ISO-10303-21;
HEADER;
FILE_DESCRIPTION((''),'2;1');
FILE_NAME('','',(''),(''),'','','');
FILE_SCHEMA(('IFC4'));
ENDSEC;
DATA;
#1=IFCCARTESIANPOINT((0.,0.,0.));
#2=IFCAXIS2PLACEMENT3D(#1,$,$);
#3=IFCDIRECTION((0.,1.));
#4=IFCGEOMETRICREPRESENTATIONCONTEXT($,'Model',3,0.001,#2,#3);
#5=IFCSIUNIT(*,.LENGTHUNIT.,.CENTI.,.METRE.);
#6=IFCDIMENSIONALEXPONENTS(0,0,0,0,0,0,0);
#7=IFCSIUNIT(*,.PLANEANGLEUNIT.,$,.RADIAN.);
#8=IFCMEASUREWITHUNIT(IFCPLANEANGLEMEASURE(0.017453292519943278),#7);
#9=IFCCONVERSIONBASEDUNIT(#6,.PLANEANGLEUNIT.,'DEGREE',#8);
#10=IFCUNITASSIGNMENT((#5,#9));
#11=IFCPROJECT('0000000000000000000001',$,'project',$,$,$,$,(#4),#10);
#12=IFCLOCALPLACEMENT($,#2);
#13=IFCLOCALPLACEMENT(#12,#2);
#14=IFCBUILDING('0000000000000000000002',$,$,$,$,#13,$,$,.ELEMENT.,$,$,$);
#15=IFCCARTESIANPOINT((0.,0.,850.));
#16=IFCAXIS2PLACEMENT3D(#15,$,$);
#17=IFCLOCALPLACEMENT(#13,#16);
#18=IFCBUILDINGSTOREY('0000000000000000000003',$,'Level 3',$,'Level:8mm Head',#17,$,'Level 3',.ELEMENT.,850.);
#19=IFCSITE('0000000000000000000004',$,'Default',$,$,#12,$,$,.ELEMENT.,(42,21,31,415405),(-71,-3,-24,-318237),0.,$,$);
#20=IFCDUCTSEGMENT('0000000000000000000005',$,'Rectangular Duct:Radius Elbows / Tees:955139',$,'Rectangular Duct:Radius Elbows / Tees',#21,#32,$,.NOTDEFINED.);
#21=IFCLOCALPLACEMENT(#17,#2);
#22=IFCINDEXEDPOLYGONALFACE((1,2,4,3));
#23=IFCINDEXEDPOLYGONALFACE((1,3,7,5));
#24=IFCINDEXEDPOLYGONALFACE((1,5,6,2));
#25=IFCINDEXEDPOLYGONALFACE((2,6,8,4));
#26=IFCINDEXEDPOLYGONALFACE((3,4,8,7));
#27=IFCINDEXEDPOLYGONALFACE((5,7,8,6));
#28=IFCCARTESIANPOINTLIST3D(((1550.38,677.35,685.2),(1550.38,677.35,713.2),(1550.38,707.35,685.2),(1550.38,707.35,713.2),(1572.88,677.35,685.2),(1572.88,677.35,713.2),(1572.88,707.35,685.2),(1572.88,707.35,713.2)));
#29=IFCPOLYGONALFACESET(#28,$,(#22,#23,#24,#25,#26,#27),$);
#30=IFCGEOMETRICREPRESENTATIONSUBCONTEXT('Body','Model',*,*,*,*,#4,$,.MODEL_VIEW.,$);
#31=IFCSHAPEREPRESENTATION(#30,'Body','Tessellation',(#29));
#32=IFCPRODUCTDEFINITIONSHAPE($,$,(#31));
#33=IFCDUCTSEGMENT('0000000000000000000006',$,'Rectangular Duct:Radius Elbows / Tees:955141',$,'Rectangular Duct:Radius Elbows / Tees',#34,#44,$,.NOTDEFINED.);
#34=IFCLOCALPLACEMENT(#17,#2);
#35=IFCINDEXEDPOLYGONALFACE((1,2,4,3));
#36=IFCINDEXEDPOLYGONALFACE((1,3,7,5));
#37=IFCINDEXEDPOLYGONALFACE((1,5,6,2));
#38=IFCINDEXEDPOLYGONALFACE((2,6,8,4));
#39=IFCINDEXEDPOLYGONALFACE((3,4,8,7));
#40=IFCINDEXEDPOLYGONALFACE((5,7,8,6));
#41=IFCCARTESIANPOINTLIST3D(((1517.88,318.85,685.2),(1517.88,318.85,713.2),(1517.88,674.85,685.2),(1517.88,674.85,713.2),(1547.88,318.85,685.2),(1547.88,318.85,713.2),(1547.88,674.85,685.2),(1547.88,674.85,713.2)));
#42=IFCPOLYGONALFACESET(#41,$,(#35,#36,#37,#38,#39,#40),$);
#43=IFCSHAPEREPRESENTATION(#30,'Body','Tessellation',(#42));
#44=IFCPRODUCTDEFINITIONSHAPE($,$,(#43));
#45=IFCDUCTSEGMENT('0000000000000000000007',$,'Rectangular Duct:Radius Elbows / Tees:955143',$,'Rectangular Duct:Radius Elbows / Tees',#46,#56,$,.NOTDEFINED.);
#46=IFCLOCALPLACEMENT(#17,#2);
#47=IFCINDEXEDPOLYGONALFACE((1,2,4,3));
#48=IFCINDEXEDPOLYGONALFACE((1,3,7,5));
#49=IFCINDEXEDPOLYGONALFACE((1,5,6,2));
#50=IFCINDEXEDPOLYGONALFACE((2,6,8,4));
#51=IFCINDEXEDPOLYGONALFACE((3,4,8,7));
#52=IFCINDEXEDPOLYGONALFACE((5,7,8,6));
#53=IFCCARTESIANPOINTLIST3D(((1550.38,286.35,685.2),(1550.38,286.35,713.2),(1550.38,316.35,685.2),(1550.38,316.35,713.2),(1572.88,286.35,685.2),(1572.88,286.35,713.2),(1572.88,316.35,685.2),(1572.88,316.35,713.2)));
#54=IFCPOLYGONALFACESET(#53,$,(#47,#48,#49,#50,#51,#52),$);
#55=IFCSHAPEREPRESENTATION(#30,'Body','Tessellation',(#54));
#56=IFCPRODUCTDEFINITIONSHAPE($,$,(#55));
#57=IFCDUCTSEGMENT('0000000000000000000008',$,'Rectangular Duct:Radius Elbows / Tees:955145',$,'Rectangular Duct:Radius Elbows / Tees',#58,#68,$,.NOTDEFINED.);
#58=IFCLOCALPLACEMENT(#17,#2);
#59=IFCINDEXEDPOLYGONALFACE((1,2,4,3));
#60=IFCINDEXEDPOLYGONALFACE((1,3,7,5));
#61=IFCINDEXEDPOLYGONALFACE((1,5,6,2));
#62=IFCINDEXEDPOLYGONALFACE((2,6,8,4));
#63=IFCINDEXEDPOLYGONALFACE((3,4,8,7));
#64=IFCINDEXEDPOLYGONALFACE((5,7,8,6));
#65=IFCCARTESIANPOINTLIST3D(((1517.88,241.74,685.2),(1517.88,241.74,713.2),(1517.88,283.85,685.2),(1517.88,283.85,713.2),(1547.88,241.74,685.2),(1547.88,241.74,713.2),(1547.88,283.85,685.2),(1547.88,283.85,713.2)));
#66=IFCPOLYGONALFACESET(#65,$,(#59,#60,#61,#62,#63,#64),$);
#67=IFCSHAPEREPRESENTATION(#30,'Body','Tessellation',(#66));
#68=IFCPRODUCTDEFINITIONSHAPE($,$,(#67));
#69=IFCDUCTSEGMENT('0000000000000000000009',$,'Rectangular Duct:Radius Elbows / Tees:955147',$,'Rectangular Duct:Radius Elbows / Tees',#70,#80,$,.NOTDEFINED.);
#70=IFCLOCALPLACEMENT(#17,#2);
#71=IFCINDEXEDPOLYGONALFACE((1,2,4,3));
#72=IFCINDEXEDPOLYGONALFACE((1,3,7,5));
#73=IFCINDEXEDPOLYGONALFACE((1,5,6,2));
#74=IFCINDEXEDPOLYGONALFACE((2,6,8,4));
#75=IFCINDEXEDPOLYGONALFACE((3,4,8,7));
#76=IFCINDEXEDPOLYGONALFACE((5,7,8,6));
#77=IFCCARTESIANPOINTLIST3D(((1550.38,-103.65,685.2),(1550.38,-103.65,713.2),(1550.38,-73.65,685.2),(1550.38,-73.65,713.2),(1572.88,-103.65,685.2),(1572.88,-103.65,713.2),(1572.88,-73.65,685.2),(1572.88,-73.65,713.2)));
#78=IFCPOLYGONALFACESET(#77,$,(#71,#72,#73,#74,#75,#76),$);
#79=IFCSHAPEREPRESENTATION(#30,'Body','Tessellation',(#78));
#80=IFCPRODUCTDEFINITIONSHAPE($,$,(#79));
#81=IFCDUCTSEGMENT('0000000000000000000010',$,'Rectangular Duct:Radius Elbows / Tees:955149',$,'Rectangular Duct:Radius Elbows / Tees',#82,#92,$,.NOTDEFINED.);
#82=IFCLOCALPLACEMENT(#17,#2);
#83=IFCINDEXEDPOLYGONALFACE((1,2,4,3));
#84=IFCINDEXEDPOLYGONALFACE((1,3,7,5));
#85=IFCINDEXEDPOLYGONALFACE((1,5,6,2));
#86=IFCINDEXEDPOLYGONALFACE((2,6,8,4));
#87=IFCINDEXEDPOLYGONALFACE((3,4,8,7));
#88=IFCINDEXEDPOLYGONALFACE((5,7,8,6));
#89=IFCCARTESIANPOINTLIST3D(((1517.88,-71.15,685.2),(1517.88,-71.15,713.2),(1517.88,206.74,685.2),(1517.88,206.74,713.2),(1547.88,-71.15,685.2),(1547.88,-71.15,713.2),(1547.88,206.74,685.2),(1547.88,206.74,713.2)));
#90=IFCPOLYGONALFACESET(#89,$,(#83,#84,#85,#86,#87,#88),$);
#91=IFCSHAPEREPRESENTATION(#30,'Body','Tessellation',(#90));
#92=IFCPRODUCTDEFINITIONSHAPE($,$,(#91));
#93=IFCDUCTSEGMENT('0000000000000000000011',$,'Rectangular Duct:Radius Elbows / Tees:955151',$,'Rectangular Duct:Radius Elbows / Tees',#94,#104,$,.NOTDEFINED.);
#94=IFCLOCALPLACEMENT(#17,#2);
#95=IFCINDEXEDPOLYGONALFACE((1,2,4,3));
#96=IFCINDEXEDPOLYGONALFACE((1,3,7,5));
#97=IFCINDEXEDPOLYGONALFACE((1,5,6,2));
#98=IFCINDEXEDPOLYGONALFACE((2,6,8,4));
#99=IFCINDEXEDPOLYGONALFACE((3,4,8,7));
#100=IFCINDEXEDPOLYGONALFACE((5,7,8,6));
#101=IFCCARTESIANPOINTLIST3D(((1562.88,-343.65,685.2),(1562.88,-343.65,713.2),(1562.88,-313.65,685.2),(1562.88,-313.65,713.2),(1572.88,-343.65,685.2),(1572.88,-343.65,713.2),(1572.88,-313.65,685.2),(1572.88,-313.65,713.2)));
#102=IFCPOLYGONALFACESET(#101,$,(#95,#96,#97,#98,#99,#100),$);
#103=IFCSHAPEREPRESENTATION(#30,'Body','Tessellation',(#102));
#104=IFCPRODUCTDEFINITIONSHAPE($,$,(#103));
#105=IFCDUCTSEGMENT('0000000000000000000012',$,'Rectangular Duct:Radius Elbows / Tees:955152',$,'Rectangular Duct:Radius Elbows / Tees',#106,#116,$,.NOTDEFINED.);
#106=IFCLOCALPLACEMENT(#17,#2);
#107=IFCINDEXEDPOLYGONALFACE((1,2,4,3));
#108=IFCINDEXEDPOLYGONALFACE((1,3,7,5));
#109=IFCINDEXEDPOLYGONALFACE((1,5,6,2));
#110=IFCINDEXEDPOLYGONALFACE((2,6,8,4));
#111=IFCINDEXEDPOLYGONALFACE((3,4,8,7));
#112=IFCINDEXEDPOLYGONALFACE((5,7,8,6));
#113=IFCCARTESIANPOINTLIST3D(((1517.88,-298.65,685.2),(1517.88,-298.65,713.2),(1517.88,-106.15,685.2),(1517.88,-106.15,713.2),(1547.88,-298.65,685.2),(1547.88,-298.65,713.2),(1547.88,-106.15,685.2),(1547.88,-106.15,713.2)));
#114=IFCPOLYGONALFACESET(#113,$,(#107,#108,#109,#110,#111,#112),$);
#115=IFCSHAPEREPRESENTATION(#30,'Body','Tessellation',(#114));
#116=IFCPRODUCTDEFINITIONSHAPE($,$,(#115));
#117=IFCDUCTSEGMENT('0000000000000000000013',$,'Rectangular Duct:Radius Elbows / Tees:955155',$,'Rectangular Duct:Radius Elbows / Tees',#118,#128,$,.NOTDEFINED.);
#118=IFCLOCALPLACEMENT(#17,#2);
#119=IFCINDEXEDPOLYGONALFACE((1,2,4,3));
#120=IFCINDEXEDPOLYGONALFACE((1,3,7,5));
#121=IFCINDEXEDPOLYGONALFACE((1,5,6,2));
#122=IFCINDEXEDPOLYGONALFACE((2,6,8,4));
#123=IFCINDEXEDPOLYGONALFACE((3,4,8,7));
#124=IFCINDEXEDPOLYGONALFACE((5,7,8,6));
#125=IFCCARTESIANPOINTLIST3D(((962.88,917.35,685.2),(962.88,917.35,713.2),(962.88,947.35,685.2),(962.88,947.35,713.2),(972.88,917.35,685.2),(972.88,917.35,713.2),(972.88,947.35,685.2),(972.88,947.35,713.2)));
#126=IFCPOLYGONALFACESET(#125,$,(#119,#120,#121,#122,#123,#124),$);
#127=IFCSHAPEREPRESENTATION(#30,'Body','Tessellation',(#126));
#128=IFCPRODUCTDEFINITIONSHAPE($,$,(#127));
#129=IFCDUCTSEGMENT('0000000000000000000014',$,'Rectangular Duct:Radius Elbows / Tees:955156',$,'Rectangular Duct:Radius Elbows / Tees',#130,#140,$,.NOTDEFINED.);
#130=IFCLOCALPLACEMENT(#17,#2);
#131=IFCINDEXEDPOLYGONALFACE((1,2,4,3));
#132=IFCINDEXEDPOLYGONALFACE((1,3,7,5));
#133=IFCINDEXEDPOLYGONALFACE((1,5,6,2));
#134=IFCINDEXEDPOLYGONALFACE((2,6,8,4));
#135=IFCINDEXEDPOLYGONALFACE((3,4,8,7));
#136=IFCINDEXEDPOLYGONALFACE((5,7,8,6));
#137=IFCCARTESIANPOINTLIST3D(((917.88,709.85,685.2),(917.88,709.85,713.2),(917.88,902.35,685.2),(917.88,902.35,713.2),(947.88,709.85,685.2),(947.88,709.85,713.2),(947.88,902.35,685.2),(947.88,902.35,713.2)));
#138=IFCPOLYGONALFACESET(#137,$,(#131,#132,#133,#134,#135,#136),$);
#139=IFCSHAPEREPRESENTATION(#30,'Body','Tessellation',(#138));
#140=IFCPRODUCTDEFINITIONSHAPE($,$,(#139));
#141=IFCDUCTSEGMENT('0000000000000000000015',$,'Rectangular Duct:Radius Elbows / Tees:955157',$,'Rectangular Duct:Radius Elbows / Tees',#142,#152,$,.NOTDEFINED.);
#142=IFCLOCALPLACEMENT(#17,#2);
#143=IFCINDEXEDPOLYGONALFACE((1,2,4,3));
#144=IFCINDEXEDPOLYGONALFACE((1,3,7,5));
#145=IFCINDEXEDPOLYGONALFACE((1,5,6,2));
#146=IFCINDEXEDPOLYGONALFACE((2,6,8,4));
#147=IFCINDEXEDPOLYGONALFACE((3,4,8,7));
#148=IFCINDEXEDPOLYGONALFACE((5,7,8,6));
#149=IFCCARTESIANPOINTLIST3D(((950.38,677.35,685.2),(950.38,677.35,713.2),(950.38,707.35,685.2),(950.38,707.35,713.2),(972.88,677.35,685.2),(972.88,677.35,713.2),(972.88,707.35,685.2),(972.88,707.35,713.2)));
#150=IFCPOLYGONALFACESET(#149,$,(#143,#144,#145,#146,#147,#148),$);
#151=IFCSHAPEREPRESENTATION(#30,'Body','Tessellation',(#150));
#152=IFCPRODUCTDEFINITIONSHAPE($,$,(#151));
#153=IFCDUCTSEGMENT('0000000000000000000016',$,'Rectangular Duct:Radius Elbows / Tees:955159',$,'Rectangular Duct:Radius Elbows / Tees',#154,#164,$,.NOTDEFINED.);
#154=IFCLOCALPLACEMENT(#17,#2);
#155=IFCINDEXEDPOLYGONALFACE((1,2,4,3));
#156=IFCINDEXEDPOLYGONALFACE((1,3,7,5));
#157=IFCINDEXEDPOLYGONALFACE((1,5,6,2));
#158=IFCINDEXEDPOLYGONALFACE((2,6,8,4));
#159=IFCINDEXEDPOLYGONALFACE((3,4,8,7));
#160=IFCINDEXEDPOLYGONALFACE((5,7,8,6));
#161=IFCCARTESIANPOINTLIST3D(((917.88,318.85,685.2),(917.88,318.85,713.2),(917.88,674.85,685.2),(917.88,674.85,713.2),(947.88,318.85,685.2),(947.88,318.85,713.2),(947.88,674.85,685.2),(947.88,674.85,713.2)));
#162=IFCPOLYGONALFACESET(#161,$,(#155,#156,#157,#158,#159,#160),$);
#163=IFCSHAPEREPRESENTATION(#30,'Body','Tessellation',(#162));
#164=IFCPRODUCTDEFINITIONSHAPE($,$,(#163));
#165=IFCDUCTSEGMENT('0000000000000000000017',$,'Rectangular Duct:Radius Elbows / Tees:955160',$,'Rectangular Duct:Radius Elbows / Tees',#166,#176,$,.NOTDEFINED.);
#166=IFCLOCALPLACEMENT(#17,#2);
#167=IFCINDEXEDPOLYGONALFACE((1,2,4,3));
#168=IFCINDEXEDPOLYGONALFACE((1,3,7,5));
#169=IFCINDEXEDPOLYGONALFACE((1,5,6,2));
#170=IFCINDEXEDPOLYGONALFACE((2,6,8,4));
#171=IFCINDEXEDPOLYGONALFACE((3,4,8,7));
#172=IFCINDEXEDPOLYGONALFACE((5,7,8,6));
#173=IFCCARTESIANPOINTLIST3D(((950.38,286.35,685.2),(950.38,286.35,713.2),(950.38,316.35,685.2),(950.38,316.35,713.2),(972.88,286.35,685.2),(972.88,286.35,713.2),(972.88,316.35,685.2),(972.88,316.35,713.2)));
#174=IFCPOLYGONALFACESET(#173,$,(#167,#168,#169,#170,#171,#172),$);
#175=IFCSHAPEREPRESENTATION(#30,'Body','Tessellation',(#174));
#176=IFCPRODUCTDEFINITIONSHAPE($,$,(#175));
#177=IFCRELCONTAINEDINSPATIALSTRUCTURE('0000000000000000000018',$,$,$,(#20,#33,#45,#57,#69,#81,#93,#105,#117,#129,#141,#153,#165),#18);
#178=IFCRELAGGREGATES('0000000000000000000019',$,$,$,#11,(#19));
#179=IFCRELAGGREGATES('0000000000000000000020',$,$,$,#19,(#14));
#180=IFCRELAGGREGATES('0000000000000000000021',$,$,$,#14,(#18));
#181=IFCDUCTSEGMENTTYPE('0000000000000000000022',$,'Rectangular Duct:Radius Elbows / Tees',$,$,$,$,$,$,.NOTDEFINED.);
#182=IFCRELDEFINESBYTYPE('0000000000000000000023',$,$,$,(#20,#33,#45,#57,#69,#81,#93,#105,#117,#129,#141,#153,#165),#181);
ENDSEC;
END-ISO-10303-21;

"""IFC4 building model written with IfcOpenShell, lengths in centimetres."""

from ifc_helpers import new_model, entity, si_unit, converted_unit, direction, frame, origin, place, context, subcontext, project, spatial, indexed_curve, outline, extrude, type_object, element, save


model = new_model("IFC4")

# Units and contexts
model_context = context("Model", 3, precision=0.001, world=origin(), true_north=direction((0.0, 1.0)))
body_context = subcontext(model_context, "Body", "Model", "MODEL_VIEW")
ifc_project = project(units=[si_unit("LENGTHUNIT", "METRE", prefix="CENTI"), converted_unit("PLANEANGLEUNIT", "DEGREE", entity("IfcPlaneAngleMeasure", 0.017453292519943278), si_unit("PLANEANGLEUNIT", "RADIAN"), dimensions=[0, 0, 0, 0, 0, 0, 0])], contexts=[model_context])

# Site, building, storey
site_placement = place(None, origin())
site = spatial("IfcSite", under=ifc_project, at=site_placement, Name="Default", CompositionType="ELEMENT", RefLatitude=(42, 21, 31, 415405), RefLongitude=(-71, -3, -24, -318237), RefElevation=0.0)
building_placement = place(site_placement, origin())
building = spatial("IfcBuilding", under=site, at=building_placement, CompositionType="ELEMENT")
storey_placement = place(building_placement, frame((0.0, 0.0, 850.0)))
storey = spatial("IfcBuildingStorey", under=building, at=storey_placement, Name="Level 3", ObjectType="Level:8mm Head", LongName="Level 3", CompositionType="ELEMENT", Elevation=850.0)

# Duct segments
duct_segment_type_1 = type_object("IfcDuctSegmentType", Name="Rectangular Duct:Radius Elbows / Tees", PredefinedType="NOTDEFINED")
duct_segment_1_placement = place(storey_placement, origin())
element("IfcDuctSegment", 1, at=duct_segment_1_placement, inside=storey, type_object=duct_segment_type_1, Name="Rectangular Duct:Radius Elbows / Tees:955139", ObjectType="Rectangular Duct:Radius Elbows / Tees", PredefinedType="NOTDEFINED", context=body_context, shape_type="SweptSolid", body=[
    extrude(outline(indexed_curve([(-11.25, -15.0), (11.25, -15.0), (11.25, 15.0), (-11.25, 15.0), (-11.25, -15.0)], self_intersect=False)), frame((1561.63, 692.35, 685.2)), (0.0, 0.0, 1.0), 28.0),
])
duct_segment_2_placement = place(storey_placement, origin())
element("IfcDuctSegment", 2, at=duct_segment_2_placement, inside=storey, type_object=duct_segment_type_1, Name="Rectangular Duct:Radius Elbows / Tees:955141", ObjectType="Rectangular Duct:Radius Elbows / Tees", PredefinedType="NOTDEFINED", context=body_context, shape_type="SweptSolid", body=[
    extrude(outline(indexed_curve([(-178.0, -15.0), (178.0, -15.0), (178.0, 15.0), (-178.0, 15.0), (-178.0, -15.0)], self_intersect=False)), frame((1532.88, 496.85, 685.2), z_axis=(0.0, 0.0, 1.0), x_axis=(0.0, 1.0, 0.0)), (0.0, 0.0, 1.0), 28.0),
])
duct_segment_3_placement = place(storey_placement, origin())
element("IfcDuctSegment", 3, at=duct_segment_3_placement, inside=storey, type_object=duct_segment_type_1, Name="Rectangular Duct:Radius Elbows / Tees:955143", ObjectType="Rectangular Duct:Radius Elbows / Tees", PredefinedType="NOTDEFINED", context=body_context, shape_type="SweptSolid", body=[
    extrude(outline(indexed_curve([(-11.25, -15.0), (11.25, -15.0), (11.25, 15.0), (-11.25, 15.0), (-11.25, -15.0)], self_intersect=False)), frame((1561.63, 301.35, 685.2)), (0.0, 0.0, 1.0), 28.0),
])
duct_segment_4_placement = place(storey_placement, origin())
element("IfcDuctSegment", 4, at=duct_segment_4_placement, inside=storey, type_object=duct_segment_type_1, Name="Rectangular Duct:Radius Elbows / Tees:955145", ObjectType="Rectangular Duct:Radius Elbows / Tees", PredefinedType="NOTDEFINED", context=body_context, shape_type="SweptSolid", body=[
    extrude(outline(indexed_curve([(-21.05, -15.0), (21.05, -15.0), (21.05, 15.0), (-21.05, 15.0), (-21.05, -15.0)], self_intersect=False)), frame((1532.88, 262.79, 685.2), z_axis=(0.0, 0.0, 1.0), x_axis=(0.0, 1.0, 0.0)), (0.0, 0.0, 1.0), 28.0),
])
duct_segment_5_placement = place(storey_placement, origin())
element("IfcDuctSegment", 5, at=duct_segment_5_placement, inside=storey, type_object=duct_segment_type_1, Name="Rectangular Duct:Radius Elbows / Tees:955147", ObjectType="Rectangular Duct:Radius Elbows / Tees", PredefinedType="NOTDEFINED", context=body_context, shape_type="SweptSolid", body=[
    extrude(outline(indexed_curve([(-11.25, -15.0), (11.25, -15.0), (11.25, 15.0), (-11.25, 15.0), (-11.25, -15.0)], self_intersect=False)), frame((1561.63, -88.65, 685.2)), (0.0, 0.0, 1.0), 28.0),
])
duct_segment_6_placement = place(storey_placement, origin())
element("IfcDuctSegment", 6, at=duct_segment_6_placement, inside=storey, type_object=duct_segment_type_1, Name="Rectangular Duct:Radius Elbows / Tees:955149", ObjectType="Rectangular Duct:Radius Elbows / Tees", PredefinedType="NOTDEFINED", context=body_context, shape_type="SweptSolid", body=[
    extrude(outline(indexed_curve([(-138.95, -15.0), (138.95, -15.0), (138.95, 15.0), (-138.95, 15.0), (-138.95, -15.0)], self_intersect=False)), frame((1532.88, 67.79, 685.2), z_axis=(0.0, 0.0, 1.0), x_axis=(0.0, -1.0, 0.0)), (0.0, 0.0, 1.0), 28.0),
])
duct_segment_7_placement = place(storey_placement, origin())
element("IfcDuctSegment", 7, at=duct_segment_7_placement, inside=storey, type_object=duct_segment_type_1, Name="Rectangular Duct:Radius Elbows / Tees:955151", ObjectType="Rectangular Duct:Radius Elbows / Tees", PredefinedType="NOTDEFINED", context=body_context, shape_type="SweptSolid", body=[
    extrude(outline(indexed_curve([(-5.0, -15.0), (5.0, -15.0), (5.0, 15.0), (-5.0, 15.0), (-5.0, -15.0)], self_intersect=False)), frame((1567.88, -328.65, 685.2)), (0.0, 0.0, 1.0), 28.0),
])
duct_segment_8_placement = place(storey_placement, origin())
element("IfcDuctSegment", 8, at=duct_segment_8_placement, inside=storey, type_object=duct_segment_type_1, Name="Rectangular Duct:Radius Elbows / Tees:955152", ObjectType="Rectangular Duct:Radius Elbows / Tees", PredefinedType="NOTDEFINED", context=body_context, shape_type="SweptSolid", body=[
    extrude(outline(indexed_curve([(-96.25, -15.0), (96.25, -15.0), (96.25, 15.0), (-96.25, 15.0), (-96.25, -15.0)], self_intersect=False)), frame((1532.88, -202.4, 685.2), z_axis=(0.0, 0.0, 1.0), x_axis=(0.0, -1.0, 0.0)), (0.0, 0.0, 1.0), 28.0),
])
duct_segment_9_placement = place(storey_placement, origin())
element("IfcDuctSegment", 9, at=duct_segment_9_placement, inside=storey, type_object=duct_segment_type_1, Name="Rectangular Duct:Radius Elbows / Tees:955155", ObjectType="Rectangular Duct:Radius Elbows / Tees", PredefinedType="NOTDEFINED", context=body_context, shape_type="SweptSolid", body=[
    extrude(outline(indexed_curve([(-5.0, -15.0), (5.0, -15.0), (5.0, 15.0), (-5.0, 15.0), (-5.0, -15.0)], self_intersect=False)), frame((967.88, 932.35, 685.2)), (0.0, 0.0, 1.0), 28.0),
])
duct_segment_10_placement = place(storey_placement, origin())
element("IfcDuctSegment", 10, at=duct_segment_10_placement, inside=storey, type_object=duct_segment_type_1, Name="Rectangular Duct:Radius Elbows / Tees:955156", ObjectType="Rectangular Duct:Radius Elbows / Tees", PredefinedType="NOTDEFINED", context=body_context, shape_type="SweptSolid", body=[
    extrude(outline(indexed_curve([(-96.25, -15.0), (96.25, -15.0), (96.25, 15.0), (-96.25, 15.0), (-96.25, -15.0)], self_intersect=False)), frame((932.88, 806.1, 685.2), z_axis=(0.0, 0.0, 1.0), x_axis=(0.0, 1.0, 0.0)), (0.0, 0.0, 1.0), 28.0),
])
duct_segment_11_placement = place(storey_placement, origin())
element("IfcDuctSegment", 11, at=duct_segment_11_placement, inside=storey, type_object=duct_segment_type_1, Name="Rectangular Duct:Radius Elbows / Tees:955157", ObjectType="Rectangular Duct:Radius Elbows / Tees", PredefinedType="NOTDEFINED", context=body_context, shape_type="SweptSolid", body=[
    extrude(outline(indexed_curve([(-11.25, -15.0), (11.25, -15.0), (11.25, 15.0), (-11.25, 15.0), (-11.25, -15.0)], self_intersect=False)), frame((961.63, 692.35, 685.2)), (0.0, 0.0, 1.0), 28.0),
])
duct_segment_12_placement = place(storey_placement, origin())
element("IfcDuctSegment", 12, at=duct_segment_12_placement, inside=storey, type_object=duct_segment_type_1, Name="Rectangular Duct:Radius Elbows / Tees:955159", ObjectType="Rectangular Duct:Radius Elbows / Tees", PredefinedType="NOTDEFINED", context=body_context, shape_type="SweptSolid", body=[
    extrude(outline(indexed_curve([(-178.0, -15.0), (178.0, -15.0), (178.0, 15.0), (-178.0, 15.0), (-178.0, -15.0)], self_intersect=False)), frame((932.88, 496.85, 685.2), z_axis=(0.0, 0.0, 1.0), x_axis=(0.0, 1.0, 0.0)), (0.0, 0.0, 1.0), 28.0),
])
duct_segment_13_placement = place(storey_placement, origin())
element("IfcDuctSegment", 13, at=duct_segment_13_placement, inside=storey, type_object=duct_segment_type_1, Name="Rectangular Duct:Radius Elbows / Tees:955160", ObjectType="Rectangular Duct:Radius Elbows / Tees", PredefinedType="NOTDEFINED", context=body_context, shape_type="SweptSolid", body=[
    extrude(outline(indexed_curve([(-11.25, -15.0), (11.25, -15.0), (11.25, 15.0), (-11.25, 15.0), (-11.25, -15.0)], self_intersect=False)), frame((961.63, 301.35, 685.2)), (0.0, 0.0, 1.0), 28.0),
])

save(model, "model.ifc")
